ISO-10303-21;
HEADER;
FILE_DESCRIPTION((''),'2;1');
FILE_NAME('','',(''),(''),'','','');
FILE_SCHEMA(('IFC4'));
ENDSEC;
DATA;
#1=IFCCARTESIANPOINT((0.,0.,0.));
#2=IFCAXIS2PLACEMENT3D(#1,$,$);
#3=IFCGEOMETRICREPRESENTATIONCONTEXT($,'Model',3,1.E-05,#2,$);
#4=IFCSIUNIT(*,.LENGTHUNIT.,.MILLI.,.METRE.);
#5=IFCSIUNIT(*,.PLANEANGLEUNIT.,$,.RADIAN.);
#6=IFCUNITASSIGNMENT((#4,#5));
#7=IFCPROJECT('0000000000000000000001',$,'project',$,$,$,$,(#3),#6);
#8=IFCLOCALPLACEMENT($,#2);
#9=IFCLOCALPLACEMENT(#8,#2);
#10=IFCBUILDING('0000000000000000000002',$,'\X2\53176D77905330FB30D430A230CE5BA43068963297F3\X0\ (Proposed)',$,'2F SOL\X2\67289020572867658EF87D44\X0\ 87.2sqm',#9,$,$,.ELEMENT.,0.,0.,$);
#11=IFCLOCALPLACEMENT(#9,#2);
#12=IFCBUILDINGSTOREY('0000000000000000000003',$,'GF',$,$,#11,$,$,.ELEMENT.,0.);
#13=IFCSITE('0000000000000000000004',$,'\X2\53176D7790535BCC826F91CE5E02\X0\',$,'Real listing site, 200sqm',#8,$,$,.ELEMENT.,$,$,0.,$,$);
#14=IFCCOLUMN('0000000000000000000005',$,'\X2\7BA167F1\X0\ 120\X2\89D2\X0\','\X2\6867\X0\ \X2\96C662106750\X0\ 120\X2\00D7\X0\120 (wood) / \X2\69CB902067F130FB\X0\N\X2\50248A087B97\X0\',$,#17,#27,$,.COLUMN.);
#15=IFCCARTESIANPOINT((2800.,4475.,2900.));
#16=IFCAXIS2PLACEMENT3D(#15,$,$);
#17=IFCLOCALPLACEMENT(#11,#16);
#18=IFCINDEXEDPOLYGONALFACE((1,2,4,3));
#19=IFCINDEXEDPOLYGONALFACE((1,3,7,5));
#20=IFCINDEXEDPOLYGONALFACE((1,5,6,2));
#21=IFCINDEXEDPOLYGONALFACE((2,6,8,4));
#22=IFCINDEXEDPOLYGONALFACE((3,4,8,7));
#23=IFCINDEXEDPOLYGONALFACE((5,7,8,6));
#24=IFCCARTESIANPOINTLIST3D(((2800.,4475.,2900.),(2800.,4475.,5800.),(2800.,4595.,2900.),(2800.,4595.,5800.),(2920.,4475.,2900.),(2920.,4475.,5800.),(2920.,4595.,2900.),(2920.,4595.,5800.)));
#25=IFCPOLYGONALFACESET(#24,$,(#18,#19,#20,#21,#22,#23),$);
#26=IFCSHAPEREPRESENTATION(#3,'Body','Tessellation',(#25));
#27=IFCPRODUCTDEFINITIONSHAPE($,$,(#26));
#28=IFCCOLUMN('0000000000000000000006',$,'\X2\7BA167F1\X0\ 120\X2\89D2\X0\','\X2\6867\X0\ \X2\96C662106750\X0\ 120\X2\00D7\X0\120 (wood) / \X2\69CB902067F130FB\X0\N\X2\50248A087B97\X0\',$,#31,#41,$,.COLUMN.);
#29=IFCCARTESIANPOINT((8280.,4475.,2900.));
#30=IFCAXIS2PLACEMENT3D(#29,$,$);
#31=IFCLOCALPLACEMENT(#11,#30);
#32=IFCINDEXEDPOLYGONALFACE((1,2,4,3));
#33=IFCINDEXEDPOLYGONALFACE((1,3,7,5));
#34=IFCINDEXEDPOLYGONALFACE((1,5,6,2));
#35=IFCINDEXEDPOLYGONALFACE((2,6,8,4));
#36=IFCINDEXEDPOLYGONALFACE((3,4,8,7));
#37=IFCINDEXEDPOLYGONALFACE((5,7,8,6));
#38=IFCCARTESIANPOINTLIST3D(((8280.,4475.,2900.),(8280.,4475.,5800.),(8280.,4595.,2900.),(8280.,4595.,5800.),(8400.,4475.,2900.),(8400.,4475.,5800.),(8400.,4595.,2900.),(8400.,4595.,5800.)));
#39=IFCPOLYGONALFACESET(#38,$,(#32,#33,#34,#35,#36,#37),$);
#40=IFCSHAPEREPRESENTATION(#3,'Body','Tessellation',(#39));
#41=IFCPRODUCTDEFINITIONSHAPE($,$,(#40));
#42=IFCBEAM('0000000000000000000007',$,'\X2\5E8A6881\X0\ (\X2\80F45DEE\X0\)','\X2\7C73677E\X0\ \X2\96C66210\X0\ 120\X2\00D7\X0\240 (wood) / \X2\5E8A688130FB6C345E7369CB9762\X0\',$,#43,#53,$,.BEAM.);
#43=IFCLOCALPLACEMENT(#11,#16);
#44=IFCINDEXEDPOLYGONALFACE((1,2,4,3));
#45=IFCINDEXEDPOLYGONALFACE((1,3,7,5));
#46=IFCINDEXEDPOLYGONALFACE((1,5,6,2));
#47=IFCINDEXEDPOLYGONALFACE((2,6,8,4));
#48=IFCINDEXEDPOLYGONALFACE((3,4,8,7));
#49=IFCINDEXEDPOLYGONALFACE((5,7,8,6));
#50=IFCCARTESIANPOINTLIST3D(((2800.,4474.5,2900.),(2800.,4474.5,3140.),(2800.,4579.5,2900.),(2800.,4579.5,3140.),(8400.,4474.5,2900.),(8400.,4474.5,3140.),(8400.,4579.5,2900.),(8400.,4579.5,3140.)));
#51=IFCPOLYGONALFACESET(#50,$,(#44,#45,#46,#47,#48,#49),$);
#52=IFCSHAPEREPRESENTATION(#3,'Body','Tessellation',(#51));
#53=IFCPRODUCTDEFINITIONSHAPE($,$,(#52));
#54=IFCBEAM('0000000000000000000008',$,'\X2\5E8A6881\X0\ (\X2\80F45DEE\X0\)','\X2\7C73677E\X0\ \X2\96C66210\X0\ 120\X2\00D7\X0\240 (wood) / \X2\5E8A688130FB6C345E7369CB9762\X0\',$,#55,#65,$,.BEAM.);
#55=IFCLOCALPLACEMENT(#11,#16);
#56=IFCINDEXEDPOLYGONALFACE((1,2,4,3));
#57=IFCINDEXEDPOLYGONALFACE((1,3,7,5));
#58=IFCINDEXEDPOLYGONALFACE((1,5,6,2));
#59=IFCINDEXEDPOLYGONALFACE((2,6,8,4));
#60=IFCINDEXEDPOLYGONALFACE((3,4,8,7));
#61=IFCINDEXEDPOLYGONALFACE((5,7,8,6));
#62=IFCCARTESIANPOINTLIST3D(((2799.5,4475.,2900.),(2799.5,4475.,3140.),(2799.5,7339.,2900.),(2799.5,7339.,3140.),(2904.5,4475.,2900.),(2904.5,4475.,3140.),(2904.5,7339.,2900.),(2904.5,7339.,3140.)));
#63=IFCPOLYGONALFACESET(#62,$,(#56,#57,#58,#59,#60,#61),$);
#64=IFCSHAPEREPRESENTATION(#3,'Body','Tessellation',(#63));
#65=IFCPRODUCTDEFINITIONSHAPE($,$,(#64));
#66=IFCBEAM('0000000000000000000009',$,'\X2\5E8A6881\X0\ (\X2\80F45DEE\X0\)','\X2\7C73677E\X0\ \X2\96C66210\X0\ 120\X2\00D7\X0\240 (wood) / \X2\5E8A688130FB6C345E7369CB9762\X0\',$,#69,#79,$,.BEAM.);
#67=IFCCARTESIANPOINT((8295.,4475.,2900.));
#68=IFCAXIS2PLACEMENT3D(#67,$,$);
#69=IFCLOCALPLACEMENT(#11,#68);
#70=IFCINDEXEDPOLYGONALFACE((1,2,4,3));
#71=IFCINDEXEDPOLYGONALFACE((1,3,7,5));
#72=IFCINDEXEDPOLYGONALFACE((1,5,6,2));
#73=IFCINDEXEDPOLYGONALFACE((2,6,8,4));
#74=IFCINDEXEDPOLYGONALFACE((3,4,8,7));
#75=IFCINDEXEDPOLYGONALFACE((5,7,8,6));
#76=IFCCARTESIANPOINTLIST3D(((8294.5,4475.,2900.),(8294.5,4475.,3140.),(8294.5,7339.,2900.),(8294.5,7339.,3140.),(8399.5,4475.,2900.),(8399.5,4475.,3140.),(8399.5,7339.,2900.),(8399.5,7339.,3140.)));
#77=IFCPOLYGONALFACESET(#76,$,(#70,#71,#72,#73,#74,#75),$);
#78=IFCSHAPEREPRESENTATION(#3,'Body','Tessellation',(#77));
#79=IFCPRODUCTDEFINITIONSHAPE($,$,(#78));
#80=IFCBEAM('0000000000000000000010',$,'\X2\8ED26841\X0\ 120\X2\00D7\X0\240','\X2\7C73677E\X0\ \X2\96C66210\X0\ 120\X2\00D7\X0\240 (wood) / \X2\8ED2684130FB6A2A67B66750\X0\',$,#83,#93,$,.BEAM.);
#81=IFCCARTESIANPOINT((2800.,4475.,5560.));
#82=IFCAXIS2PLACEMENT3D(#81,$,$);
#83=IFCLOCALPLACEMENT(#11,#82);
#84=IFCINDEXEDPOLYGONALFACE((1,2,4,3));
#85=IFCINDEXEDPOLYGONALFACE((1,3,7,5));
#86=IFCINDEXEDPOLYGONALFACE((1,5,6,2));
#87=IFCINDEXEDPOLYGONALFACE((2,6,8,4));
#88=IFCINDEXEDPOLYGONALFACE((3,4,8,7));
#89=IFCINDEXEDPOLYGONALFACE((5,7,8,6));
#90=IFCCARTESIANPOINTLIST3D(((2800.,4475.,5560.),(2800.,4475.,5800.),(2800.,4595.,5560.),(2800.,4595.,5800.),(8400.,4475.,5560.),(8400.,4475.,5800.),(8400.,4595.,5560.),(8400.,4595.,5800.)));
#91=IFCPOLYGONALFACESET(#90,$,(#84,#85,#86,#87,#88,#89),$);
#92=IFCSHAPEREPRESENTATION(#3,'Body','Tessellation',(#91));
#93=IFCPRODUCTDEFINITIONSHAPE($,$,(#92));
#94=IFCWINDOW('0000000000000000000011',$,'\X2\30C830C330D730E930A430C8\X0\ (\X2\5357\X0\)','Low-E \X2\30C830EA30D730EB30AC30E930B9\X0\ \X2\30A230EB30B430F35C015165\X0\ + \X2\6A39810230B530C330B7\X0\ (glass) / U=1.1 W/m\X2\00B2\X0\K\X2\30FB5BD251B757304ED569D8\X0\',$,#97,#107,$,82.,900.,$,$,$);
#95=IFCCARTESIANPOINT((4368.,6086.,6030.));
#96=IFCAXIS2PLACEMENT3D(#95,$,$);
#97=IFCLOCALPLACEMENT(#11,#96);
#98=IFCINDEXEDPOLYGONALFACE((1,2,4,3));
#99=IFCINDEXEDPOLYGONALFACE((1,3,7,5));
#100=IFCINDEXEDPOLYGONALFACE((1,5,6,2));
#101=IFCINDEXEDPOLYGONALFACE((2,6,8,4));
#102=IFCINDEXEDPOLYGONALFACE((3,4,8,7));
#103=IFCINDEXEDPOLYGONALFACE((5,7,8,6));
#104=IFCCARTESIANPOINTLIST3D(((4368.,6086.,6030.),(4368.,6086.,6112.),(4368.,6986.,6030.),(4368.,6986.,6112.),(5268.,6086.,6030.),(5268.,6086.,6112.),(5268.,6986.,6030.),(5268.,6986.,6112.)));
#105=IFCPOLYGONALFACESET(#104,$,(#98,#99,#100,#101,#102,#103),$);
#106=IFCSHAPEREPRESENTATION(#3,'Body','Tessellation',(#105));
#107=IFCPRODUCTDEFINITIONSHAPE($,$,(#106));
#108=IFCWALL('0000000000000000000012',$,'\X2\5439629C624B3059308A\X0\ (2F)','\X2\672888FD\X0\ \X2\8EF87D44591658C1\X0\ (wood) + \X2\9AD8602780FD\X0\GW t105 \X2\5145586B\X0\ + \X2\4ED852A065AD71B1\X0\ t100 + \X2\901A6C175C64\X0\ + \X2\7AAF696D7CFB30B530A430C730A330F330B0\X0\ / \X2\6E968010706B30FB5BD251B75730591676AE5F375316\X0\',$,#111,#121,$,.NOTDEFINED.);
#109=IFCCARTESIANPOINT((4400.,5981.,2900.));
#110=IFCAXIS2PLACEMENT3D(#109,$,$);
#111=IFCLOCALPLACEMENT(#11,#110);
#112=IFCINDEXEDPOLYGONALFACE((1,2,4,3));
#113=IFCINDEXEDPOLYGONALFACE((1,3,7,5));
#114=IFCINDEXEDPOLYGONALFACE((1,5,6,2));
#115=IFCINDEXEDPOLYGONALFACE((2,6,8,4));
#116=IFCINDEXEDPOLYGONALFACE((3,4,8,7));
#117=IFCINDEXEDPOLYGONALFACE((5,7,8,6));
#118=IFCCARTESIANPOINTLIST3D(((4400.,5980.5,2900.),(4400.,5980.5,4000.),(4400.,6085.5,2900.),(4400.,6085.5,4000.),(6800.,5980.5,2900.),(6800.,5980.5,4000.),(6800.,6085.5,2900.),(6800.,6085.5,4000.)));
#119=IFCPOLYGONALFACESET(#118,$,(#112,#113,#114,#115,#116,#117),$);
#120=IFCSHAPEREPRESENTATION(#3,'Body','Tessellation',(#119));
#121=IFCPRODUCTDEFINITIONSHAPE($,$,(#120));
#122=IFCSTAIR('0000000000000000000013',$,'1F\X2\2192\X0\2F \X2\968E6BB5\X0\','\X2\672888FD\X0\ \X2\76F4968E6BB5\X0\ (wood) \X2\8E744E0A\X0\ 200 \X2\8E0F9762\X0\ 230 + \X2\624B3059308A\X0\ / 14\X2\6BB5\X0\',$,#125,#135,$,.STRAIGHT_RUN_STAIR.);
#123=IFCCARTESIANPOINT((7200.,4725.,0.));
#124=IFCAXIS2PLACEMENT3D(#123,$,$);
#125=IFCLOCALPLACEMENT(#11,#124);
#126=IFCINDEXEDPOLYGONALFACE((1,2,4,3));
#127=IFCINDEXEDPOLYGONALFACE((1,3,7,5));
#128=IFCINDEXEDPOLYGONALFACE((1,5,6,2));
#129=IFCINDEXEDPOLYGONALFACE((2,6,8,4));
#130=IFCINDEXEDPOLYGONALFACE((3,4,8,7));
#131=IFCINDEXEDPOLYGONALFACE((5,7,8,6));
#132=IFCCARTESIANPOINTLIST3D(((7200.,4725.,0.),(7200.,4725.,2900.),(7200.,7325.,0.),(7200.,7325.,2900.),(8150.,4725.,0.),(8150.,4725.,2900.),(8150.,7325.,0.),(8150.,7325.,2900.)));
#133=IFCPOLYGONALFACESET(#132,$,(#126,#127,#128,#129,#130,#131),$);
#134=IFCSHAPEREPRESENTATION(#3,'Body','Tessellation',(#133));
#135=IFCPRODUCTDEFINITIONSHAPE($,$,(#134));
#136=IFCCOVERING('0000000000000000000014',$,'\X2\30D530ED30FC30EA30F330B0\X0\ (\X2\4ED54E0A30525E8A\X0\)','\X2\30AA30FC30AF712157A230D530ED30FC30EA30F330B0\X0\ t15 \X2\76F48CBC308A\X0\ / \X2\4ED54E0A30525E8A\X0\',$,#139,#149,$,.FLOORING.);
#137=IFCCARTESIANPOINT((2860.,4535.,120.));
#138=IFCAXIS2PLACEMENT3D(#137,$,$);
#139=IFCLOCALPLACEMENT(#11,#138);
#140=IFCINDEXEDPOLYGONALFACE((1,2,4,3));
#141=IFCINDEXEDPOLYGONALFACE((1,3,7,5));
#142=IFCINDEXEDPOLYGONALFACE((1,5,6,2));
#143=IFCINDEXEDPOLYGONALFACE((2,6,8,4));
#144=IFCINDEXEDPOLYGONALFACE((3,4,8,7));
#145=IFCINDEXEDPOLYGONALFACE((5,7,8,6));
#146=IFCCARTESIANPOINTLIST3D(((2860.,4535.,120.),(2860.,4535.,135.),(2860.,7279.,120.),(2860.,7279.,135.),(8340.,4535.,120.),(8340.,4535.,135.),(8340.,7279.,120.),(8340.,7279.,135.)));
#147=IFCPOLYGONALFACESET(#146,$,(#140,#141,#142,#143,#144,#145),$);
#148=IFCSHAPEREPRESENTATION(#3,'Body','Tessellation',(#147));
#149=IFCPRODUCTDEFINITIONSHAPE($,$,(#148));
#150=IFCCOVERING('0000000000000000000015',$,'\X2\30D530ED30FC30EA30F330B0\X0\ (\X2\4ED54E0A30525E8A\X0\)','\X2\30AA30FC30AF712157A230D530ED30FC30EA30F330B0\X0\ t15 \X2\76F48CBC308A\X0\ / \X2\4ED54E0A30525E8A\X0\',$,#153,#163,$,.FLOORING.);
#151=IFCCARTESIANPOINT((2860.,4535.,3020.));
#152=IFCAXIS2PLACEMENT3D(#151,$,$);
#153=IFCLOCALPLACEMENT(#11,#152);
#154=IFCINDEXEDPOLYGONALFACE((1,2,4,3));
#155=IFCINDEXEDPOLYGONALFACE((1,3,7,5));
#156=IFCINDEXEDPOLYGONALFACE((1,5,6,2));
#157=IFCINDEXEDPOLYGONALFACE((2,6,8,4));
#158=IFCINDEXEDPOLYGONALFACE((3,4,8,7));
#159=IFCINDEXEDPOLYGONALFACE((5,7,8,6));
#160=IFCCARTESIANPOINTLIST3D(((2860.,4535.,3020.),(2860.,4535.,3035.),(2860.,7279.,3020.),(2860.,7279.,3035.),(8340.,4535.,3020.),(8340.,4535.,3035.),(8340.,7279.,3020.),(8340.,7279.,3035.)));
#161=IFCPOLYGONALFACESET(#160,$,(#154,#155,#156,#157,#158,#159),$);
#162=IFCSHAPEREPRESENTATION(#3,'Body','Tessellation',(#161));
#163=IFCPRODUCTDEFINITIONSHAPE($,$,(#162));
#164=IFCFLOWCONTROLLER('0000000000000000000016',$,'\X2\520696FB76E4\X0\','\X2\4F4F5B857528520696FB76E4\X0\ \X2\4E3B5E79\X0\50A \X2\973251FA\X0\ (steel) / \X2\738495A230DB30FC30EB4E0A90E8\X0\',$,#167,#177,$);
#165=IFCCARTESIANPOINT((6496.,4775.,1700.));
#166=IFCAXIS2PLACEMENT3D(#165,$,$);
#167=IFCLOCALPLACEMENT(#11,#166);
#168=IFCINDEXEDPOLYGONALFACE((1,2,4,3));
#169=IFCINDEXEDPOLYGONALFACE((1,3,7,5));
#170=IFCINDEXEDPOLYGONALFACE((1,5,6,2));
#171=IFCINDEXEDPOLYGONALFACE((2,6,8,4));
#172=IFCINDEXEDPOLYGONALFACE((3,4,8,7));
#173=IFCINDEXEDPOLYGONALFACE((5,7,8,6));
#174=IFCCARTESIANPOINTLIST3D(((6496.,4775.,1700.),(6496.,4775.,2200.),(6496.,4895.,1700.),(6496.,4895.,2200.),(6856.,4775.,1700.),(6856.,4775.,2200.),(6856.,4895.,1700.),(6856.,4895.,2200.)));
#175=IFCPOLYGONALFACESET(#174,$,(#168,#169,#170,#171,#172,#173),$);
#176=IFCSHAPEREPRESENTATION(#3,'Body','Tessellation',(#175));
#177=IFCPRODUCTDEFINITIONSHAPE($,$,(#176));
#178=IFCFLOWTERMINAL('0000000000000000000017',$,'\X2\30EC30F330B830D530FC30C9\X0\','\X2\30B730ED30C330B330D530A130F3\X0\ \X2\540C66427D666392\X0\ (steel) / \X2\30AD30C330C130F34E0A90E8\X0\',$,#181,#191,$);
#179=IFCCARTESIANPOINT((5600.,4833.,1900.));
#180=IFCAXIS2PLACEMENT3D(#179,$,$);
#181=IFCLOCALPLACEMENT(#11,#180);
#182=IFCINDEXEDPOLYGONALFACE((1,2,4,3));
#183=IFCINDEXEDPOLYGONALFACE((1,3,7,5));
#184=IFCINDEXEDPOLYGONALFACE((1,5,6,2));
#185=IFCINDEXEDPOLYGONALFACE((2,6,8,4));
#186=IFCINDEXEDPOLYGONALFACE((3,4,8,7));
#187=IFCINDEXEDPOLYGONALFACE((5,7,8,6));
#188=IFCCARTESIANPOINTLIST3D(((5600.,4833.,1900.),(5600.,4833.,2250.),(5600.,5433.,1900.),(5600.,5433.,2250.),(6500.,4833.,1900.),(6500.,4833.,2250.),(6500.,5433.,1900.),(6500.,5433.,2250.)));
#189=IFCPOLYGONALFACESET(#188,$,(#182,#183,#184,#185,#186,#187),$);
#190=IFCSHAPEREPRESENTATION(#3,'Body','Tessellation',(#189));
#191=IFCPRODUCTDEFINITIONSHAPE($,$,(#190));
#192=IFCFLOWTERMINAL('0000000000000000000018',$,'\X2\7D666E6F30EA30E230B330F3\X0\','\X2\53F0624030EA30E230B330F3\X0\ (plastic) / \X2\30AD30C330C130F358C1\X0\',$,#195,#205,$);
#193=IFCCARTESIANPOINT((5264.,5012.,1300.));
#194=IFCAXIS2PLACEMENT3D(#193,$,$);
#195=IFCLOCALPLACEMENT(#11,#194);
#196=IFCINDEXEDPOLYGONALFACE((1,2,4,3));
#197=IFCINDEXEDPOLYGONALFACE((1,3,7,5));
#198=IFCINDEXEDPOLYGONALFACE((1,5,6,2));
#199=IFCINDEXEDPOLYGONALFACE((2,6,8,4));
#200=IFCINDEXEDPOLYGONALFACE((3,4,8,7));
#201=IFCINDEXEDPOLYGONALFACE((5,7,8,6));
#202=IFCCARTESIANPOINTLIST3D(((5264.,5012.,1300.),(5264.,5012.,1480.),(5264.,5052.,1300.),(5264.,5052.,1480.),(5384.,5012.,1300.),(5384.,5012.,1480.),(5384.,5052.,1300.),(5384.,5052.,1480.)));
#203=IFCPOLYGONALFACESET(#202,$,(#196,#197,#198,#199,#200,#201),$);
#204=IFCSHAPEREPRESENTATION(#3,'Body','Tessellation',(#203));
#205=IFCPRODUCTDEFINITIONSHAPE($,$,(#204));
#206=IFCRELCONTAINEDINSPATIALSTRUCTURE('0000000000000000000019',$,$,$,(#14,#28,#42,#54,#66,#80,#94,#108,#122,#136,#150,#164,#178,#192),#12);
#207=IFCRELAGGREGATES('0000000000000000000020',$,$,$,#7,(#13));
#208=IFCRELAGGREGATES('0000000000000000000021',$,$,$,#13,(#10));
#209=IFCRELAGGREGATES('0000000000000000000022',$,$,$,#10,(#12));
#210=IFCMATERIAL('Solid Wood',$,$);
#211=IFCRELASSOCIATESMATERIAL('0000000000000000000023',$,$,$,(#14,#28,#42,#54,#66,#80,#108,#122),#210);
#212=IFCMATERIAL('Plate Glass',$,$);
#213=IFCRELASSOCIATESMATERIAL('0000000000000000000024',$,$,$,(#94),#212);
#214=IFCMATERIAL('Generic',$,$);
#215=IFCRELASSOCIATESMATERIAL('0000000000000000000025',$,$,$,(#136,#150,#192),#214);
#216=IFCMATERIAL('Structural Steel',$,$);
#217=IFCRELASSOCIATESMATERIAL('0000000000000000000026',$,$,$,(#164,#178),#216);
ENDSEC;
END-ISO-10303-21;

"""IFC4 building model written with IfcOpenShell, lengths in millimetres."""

from ifc_helpers import new_model, si_unit, frame, frame_2d, origin, place, context, project, spatial, rectangle, extrude, material, element, save


model = new_model("IFC4")

# Units and contexts
model_context = context("Model", 3, precision=1e-05, world=origin())
ifc_project = project(units=[si_unit("LENGTHUNIT", "METRE", prefix="MILLI"), si_unit("PLANEANGLEUNIT", "RADIAN")], contexts=[model_context])

# Site, building, storey
site_placement = place(None, origin())
site = spatial("IfcSite", under=ifc_project, at=site_placement, Name="北海道富良野市", ObjectType="Real listing site, 200sqm", CompositionType="ELEMENT", RefElevation=0.0)
building_placement = place(site_placement, origin())
building = spatial("IfcBuilding", under=site, at=building_placement, Name="北海道・ピアノ室と防音 (Proposed)", ObjectType="2F SOL木造在来軸組 87.2sqm", CompositionType="ELEMENT", ElevationOfRefHeight=0.0, ElevationOfTerrain=0.0)
storey_placement = place(building_placement, origin())
storey = spatial("IfcBuildingStorey", under=building, at=storey_placement, Name="GF", CompositionType="ELEMENT", Elevation=0.0)

# Columns
ifc_material_1 = material(Name="Solid Wood")
column_1_placement = place(storey_placement, frame((2800.0, 4475.0, 2900.0)))
element("IfcColumn", 1, at=column_1_placement, inside=storey, material=ifc_material_1, Name="管柱 120角", Description="桧 集成材 120×120 (wood) / 構造柱・N値計算", PredefinedType="COLUMN", context=model_context, shape_type="SweptSolid", body=[
    extrude(rectangle(XDim=120.0, YDim=120.0, at=frame_2d((60.0, 60.0))), frame((2800.0, 4475.0, 2900.0)), (0.0, 0.0, 1.0), 2900.0),
])
column_2_placement = place(storey_placement, frame((8280.0, 4475.0, 2900.0)))
element("IfcColumn", 2, at=column_2_placement, inside=storey, material=ifc_material_1, Name="管柱 120角", Description="桧 集成材 120×120 (wood) / 構造柱・N値計算", PredefinedType="COLUMN", context=model_context, shape_type="SweptSolid", body=[
    extrude(rectangle(XDim=120.0, YDim=120.0, at=frame_2d((60.0, 60.0))), frame((8280.0, 4475.0, 2900.0)), (0.0, 0.0, 1.0), 2900.0),
])

# Beams
beam_1_placement = place(storey_placement, frame((2800.0, 4475.0, 2900.0)))
element("IfcBeam", 3, at=beam_1_placement, inside=storey, material=ifc_material_1, Name="床梁 (胴差)", Description="米松 集成 120×240 (wood) / 床梁・水平構面", PredefinedType="BEAM", context=model_context, shape_type="SweptSolid", body=[
    extrude(rectangle(XDim=5600.0, YDim=105.0, at=frame_2d((2800.0, 52.0))), frame((2800.0, 4475.0, 2900.0)), (0.0, 0.0, 1.0), 240.0),
])
beam_2_placement = place(storey_placement, frame((2800.0, 4475.0, 2900.0)))
element("IfcBeam", 4, at=beam_2_placement, inside=storey, material=ifc_material_1, Name="床梁 (胴差)", Description="米松 集成 120×240 (wood) / 床梁・水平構面", PredefinedType="BEAM", context=model_context, shape_type="SweptSolid", body=[
    extrude(rectangle(XDim=105.0, YDim=2864.0, at=frame_2d((52.0, 1432.0))), frame((2800.0, 4475.0, 2900.0)), (0.0, 0.0, 1.0), 240.0),
])
beam_3_placement = place(storey_placement, frame((8295.0, 4475.0, 2900.0)))
element("IfcBeam", 5, at=beam_3_placement, inside=storey, material=ifc_material_1, Name="床梁 (胴差)", Description="米松 集成 120×240 (wood) / 床梁・水平構面", PredefinedType="BEAM", context=model_context, shape_type="SweptSolid", body=[
    extrude(rectangle(XDim=105.0, YDim=2864.0, at=frame_2d((52.0, 1432.0))), frame((8295.0, 4475.0, 2900.0)), (0.0, 0.0, 1.0), 240.0),
])
beam_4_placement = place(storey_placement, frame((2800.0, 4475.0, 5560.0)))
element("IfcBeam", 6, at=beam_4_placement, inside=storey, material=ifc_material_1, Name="軒桁 120×240", Description="米松 集成 120×240 (wood) / 軒桁・横架材", PredefinedType="BEAM", context=model_context, shape_type="SweptSolid", body=[
    extrude(rectangle(XDim=5600.0, YDim=120.0, at=frame_2d((2800.0, 60.0))), frame((2800.0, 4475.0, 5560.0)), (0.0, 0.0, 1.0), 240.0),
])

# Window
ifc_material_2 = material(Name="Plate Glass")
window_placement = place(storey_placement, frame((4368.0, 6086.0, 6030.0)))
element("IfcWindow", 7, at=window_placement, inside=storey, material=ifc_material_2, Name="トップライト (南)", Description="Low-E トリプルガラス アルゴン封入 + 樹脂サッシ (glass) / U=1.1 W/m²K・寒冷地仕様", OverallHeight=82.0, OverallWidth=900.0, context=model_context, shape_type="SweptSolid", body=[
    extrude(rectangle(XDim=900.0, YDim=900.0, at=frame_2d((450.0, 450.0))), frame((4368.0, 6086.0, 6030.0)), (0.0, 0.0, 1.0), 82.0),
])

# Wall
wall_1_placement = place(storey_placement, frame((4400.0, 5981.0, 2900.0)))
element("IfcWall", 8, at=wall_1_placement, inside=storey, material=ifc_material_1, Name="吹抜手すり (2F)", Description="木製 軸組外壁 (wood) + 高性能GW t105 充填 + 付加断熱 t100 + 通気層 + 窯業系サイディング / 準耐火・寒冷地外皮強化", PredefinedType="NOTDEFINED", context=model_context, shape_type="SweptSolid", body=[
    extrude(rectangle(XDim=2400.0, YDim=105.0, at=frame_2d((1200.0, 52.0))), frame((4400.0, 5981.0, 2900.0)), (0.0, 0.0, 1.0), 1100.0),
])

# Stair
stair_placement = place(storey_placement, frame((7200.0, 4725.0, 0.0)))
element("IfcStair", 9, at=stair_placement, inside=storey, material=ifc_material_1, Name="1F→2F 階段", Description="木製 直階段 (wood) 蹴上 200 踏面 230 + 手すり / 14段", PredefinedType="STRAIGHT_RUN_STAIR", context=model_context, shape_type="SweptSolid", body=[
    extrude(rectangle(XDim=950.0, YDim=2600.0, at=frame_2d((475.0, 1300.0))), frame((7200.0, 4725.0, 0.0)), (0.0, 0.0, 1.0), 2900.0),
])

# Coverings
ifc_material_3 = material(Name="Generic")
covering_1_placement = place(storey_placement, frame((2860.0, 4535.0, 120.0)))
element("IfcCovering", 10, at=covering_1_placement, inside=storey, material=ifc_material_3, Name="フローリング (仕上げ床)", Description="オーク無垢フローリング t15 直貼り / 仕上げ床", PredefinedType="FLOORING", context=model_context, shape_type="SweptSolid", body=[
    extrude(rectangle(XDim=5480.0, YDim=2744.0, at=frame_2d((2740.0, 1372.0))), frame((2860.0, 4535.0, 120.0)), (0.0, 0.0, 1.0), 15.0),
])
covering_2_placement = place(storey_placement, frame((2860.0, 4535.0, 3020.0)))
element("IfcCovering", 11, at=covering_2_placement, inside=storey, material=ifc_material_3, Name="フローリング (仕上げ床)", Description="オーク無垢フローリング t15 直貼り / 仕上げ床", PredefinedType="FLOORING", context=model_context, shape_type="SweptSolid", body=[
    extrude(rectangle(XDim=5480.0, YDim=2744.0, at=frame_2d((2740.0, 1372.0))), frame((2860.0, 4535.0, 3020.0)), (0.0, 0.0, 1.0), 15.0),
])

# Flow controller
ifc_material_4 = material(Name="Structural Steel")
flow_controller_placement = place(storey_placement, frame((6496.0, 4775.0, 1700.0)))
element("IfcFlowController", 12, at=flow_controller_placement, inside=storey, material=ifc_material_4, Name="分電盤", Description="住宅用分電盤 主幹50A 露出 (steel) / 玄関ホール上部", context=model_context, shape_type="SweptSolid", body=[
    extrude(rectangle(XDim=360.0, YDim=120.0, at=frame_2d((180.0, 60.0))), frame((6496.0, 4775.0, 1700.0)), (0.0, 0.0, 1.0), 500.0),
])

# Flow terminals
flow_terminal_1_placement = place(storey_placement, frame((5600.0, 4833.0, 1900.0)))
element("IfcFlowTerminal", 13, at=flow_terminal_1_placement, inside=storey, material=ifc_material_4, Name="レンジフード", Description="シロッコファン 同時給排 (steel) / キッチン上部", context=model_context, shape_type="SweptSolid", body=[
    extrude(rectangle(XDim=900.0, YDim=600.0, at=frame_2d((450.0, 300.0))), frame((5600.0, 4833.0, 1900.0)), (0.0, 0.0, 1.0), 350.0),
])
flow_terminal_2_placement = place(storey_placement, frame((5264.0, 5012.0, 1300.0)))
element("IfcFlowTerminal", 14, at=flow_terminal_2_placement, inside=storey, material=ifc_material_3, Name="給湯リモコン", Description="台所リモコン (plastic) / キッチン壁", context=model_context, shape_type="SweptSolid", body=[
    extrude(rectangle(XDim=120.0, YDim=40.0, at=frame_2d((60.0, 20.0))), frame((5264.0, 5012.0, 1300.0)), (0.0, 0.0, 1.0), 180.0),
])

save(model, "model.ifc")
